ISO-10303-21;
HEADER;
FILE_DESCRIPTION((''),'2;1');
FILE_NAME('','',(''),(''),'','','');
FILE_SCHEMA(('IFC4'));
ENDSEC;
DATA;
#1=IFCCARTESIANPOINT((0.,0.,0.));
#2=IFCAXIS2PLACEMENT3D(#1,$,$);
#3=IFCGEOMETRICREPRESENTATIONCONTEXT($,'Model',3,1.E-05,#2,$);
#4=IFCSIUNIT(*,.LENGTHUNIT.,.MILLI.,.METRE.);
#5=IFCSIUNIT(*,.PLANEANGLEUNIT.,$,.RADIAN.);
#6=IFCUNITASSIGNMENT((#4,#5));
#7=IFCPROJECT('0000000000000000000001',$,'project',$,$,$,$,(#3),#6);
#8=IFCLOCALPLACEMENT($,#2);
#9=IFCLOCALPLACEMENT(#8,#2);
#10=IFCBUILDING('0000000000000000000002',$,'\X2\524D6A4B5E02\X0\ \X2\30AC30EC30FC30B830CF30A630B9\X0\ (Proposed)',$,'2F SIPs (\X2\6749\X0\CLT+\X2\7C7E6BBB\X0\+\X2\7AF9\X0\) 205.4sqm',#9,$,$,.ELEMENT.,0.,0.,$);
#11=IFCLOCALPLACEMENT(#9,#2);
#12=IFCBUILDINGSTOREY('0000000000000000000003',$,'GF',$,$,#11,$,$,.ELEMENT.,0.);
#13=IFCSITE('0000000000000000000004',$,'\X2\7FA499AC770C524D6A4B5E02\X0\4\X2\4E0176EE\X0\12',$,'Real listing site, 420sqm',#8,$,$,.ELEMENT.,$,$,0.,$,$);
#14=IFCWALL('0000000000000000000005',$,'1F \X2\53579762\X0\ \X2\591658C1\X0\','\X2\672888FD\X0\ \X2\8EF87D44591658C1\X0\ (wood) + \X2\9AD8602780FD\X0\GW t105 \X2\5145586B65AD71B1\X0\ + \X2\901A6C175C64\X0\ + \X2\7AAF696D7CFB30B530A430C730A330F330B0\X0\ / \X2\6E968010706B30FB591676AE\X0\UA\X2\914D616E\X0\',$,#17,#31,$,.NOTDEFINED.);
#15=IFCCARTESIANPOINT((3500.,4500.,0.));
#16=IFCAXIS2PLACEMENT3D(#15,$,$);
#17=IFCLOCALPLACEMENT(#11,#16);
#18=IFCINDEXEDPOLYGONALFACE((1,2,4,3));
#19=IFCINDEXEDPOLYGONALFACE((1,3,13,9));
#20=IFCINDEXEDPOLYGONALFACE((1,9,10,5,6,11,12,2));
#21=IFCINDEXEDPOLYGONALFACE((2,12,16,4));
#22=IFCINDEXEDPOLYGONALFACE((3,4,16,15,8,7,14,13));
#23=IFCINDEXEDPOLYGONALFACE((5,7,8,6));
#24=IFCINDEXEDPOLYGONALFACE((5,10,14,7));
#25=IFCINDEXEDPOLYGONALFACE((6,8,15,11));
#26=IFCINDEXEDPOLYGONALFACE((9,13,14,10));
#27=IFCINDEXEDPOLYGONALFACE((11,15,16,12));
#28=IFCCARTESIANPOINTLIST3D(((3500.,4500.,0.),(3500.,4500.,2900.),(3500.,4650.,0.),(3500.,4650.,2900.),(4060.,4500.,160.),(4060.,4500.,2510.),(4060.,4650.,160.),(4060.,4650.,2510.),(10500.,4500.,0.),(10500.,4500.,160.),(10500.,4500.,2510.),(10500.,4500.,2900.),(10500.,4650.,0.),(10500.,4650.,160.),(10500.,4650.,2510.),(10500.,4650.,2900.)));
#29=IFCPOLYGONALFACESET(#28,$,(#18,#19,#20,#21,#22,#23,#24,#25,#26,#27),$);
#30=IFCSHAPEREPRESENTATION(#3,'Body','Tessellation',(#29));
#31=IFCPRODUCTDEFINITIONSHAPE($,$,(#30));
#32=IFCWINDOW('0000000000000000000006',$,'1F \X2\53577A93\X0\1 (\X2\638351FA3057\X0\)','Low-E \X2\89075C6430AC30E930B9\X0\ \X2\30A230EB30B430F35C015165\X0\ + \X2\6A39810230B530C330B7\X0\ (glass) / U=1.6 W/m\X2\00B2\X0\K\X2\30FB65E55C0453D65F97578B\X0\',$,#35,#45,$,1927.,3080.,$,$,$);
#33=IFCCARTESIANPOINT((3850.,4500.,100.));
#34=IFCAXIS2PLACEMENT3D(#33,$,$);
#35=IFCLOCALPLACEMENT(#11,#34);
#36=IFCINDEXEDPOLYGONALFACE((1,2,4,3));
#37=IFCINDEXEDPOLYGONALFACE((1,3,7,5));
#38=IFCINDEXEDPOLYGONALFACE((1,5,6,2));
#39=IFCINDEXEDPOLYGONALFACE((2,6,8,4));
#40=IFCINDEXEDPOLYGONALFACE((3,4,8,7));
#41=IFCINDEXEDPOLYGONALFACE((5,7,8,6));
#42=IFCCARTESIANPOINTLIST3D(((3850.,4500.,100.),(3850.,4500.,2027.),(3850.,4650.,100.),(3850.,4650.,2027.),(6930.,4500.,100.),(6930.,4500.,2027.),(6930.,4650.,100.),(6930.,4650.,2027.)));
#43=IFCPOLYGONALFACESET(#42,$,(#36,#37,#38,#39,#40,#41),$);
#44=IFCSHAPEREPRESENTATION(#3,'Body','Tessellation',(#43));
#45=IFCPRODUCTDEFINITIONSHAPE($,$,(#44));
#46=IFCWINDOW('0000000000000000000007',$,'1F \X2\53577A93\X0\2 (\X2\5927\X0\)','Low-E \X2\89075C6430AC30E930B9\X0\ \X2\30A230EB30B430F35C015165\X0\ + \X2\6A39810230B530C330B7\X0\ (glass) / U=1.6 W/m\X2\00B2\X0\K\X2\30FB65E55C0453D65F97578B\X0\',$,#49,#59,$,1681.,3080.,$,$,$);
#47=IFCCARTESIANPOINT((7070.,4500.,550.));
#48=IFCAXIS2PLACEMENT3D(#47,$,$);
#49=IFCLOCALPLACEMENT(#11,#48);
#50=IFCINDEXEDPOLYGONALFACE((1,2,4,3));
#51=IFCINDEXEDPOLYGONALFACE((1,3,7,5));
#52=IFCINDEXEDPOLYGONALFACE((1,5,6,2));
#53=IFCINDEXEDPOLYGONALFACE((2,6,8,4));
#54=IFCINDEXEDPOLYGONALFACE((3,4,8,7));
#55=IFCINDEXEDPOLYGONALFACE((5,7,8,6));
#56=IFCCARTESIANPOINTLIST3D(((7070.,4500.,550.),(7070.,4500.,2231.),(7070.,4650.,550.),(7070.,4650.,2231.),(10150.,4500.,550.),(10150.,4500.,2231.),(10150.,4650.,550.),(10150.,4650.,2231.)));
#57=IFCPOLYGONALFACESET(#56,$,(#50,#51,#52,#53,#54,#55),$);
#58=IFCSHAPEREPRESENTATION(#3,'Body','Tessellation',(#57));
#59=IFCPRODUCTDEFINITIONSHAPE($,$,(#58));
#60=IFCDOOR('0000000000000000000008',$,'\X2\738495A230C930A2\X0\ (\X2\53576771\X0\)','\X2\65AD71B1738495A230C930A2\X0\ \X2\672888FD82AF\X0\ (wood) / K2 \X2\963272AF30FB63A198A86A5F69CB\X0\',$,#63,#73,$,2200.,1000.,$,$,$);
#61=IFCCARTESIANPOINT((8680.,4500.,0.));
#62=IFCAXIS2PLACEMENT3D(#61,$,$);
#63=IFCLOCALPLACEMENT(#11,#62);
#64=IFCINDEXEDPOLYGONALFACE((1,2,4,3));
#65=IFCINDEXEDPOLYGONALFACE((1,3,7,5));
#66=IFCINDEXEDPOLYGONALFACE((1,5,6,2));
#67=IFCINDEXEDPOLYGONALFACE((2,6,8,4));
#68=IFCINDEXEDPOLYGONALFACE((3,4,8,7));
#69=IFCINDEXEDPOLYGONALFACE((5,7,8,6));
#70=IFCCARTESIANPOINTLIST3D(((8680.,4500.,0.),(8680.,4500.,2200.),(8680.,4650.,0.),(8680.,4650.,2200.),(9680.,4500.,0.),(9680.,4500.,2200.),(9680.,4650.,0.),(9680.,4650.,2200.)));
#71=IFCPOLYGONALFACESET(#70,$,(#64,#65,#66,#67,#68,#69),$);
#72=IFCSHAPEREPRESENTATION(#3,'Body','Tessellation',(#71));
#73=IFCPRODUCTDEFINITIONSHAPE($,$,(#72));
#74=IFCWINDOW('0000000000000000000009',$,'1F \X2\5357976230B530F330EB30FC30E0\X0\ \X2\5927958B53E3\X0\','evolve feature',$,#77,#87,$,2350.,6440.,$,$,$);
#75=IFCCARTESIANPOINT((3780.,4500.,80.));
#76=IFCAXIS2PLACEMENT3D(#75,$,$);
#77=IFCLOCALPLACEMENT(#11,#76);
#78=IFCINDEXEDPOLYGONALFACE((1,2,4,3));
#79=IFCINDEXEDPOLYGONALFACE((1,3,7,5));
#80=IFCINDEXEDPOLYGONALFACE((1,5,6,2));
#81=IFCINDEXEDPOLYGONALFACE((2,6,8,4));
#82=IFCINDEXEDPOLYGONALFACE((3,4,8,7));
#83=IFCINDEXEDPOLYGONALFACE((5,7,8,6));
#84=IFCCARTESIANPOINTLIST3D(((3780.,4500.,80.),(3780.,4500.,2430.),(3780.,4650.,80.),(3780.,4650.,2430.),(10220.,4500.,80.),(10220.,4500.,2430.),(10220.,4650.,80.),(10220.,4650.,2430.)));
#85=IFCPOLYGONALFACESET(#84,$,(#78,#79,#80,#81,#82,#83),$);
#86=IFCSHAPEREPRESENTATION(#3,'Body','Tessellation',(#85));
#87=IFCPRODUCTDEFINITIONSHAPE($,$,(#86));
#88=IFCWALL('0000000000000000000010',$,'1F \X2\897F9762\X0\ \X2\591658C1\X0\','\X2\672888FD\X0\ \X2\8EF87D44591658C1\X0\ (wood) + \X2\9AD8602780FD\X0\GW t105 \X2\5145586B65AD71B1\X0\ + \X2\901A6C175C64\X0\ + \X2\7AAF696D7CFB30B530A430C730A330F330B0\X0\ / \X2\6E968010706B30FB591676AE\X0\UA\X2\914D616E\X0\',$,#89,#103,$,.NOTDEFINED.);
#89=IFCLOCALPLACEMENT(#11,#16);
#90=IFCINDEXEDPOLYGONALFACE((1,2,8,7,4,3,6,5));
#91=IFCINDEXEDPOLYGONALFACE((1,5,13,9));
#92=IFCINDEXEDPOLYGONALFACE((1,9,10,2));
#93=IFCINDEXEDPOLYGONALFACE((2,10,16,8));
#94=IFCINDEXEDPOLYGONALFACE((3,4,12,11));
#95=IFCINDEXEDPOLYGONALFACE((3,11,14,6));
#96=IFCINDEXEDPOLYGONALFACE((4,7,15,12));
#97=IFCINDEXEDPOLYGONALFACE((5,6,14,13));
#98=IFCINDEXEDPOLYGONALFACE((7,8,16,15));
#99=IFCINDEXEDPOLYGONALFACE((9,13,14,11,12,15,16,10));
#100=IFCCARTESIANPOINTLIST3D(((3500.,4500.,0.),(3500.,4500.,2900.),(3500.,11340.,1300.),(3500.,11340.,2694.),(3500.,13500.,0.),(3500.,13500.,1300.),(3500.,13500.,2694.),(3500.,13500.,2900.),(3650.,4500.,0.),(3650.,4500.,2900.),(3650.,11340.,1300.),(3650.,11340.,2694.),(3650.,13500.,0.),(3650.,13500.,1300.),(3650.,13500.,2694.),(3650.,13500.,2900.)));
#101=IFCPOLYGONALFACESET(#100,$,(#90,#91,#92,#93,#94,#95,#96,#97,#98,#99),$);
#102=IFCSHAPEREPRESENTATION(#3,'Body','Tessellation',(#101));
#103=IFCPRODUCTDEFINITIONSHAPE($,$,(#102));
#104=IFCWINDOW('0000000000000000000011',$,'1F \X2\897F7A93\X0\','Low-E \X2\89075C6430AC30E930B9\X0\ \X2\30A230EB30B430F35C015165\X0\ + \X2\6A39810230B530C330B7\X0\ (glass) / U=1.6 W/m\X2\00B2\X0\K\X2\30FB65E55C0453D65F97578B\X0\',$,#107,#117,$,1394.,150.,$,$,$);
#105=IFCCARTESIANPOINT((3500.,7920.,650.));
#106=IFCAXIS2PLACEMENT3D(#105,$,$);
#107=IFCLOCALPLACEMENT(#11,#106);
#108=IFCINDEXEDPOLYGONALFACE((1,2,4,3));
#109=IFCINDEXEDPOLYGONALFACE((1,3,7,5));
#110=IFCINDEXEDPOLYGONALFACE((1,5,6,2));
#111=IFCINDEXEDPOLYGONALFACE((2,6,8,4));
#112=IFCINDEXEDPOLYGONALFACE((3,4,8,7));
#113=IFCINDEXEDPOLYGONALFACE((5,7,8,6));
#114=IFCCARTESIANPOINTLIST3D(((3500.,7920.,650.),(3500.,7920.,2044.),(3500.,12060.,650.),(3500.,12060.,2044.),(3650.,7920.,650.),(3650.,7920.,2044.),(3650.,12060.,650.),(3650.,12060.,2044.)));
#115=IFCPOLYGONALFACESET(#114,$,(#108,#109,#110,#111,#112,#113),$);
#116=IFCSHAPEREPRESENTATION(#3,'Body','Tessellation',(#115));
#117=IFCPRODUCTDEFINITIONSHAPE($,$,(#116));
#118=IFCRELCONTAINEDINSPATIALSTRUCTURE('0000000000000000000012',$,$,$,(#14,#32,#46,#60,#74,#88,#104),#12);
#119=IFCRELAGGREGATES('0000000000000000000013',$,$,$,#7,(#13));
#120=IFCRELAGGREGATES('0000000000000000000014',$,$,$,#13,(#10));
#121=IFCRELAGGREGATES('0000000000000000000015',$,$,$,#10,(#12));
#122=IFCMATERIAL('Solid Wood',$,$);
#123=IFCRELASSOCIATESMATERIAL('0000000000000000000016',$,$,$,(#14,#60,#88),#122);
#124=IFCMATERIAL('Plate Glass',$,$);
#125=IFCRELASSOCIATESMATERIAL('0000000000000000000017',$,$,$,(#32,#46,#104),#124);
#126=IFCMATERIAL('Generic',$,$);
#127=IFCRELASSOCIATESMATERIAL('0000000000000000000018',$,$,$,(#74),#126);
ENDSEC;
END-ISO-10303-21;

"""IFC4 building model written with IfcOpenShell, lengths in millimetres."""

from ifc_helpers import new_model, si_unit, frame, frame_2d, origin, place, context, project, spatial, rectangle, extrude, material, element, fill, save


model = new_model("IFC4")

# Units and contexts
model_context = context("Model", 3, precision=1e-05, world=origin())
ifc_project = project(units=[si_unit("LENGTHUNIT", "METRE", prefix="MILLI"), si_unit("PLANEANGLEUNIT", "RADIAN")], contexts=[model_context])

# Site, building, storey
site_placement = place(None, origin())
site = spatial("IfcSite", under=ifc_project, at=site_placement, Name="群馬県前橋市4丁目12", ObjectType="Real listing site, 420sqm", CompositionType="ELEMENT", RefElevation=0.0)
building_placement = place(site_placement, origin())
building = spatial("IfcBuilding", under=site, at=building_placement, Name="前橋市 ガレージハウス (Proposed)", ObjectType="2F SIPs (杉CLT+籾殻+竹) 205.4sqm", CompositionType="ELEMENT", ElevationOfRefHeight=0.0, ElevationOfTerrain=0.0)
storey_placement = place(building_placement, origin())
storey = spatial("IfcBuildingStorey", under=building, at=storey_placement, Name="GF", CompositionType="ELEMENT", Elevation=0.0)

# Shared definitions
ifc_material_1 = material(Name="Solid Wood")

# Wall, openings, windows, door
wall_1_placement = place(storey_placement, frame((3500.0, 4500.0, 0.0)))
wall_1 = element("IfcWall", 1, at=wall_1_placement, inside=storey, material=ifc_material_1, Name="1F 南面 外壁", Description="木製 軸組外壁 (wood) + 高性能GW t105 充填断熱 + 通気層 + 窯業系サイディング / 準耐火・外皮UA配慮", PredefinedType="NOTDEFINED", context=model_context, shape_type="SweptSolid", body=[
    extrude(rectangle(XDim=7000.0, YDim=150.0, at=frame_2d((3500.0, 75.0))), frame((3500.0, 4500.0, 0.0)), (0.0, 0.0, 1.0), 2900.0),
])
opening_1_placement = place(storey_placement, frame((3850.0, 4500.0, 100.0)))
opening_1 = element("IfcOpeningElement", 2, at=opening_1_placement, cuts=wall_1, PredefinedType="NOTDEFINED", context=model_context, shape_type="SweptSolid", body=[
    extrude(rectangle(XDim=3080.0, YDim=150.0, at=frame_2d((1540.0, 75.0))), frame((3850.0, 4500.0, 100.0)), (0.0, 0.0, 1.0), 1927.0),
])
opening_2_placement = place(storey_placement, frame((7070.0, 4500.0, 550.0)))
opening_2 = element("IfcOpeningElement", 3, at=opening_2_placement, cuts=wall_1, PredefinedType="NOTDEFINED", context=model_context, shape_type="SweptSolid", body=[
    extrude(rectangle(XDim=3080.0, YDim=150.0, at=frame_2d((1540.0, 75.0))), frame((7070.0, 4500.0, 550.0)), (0.0, 0.0, 1.0), 1681.0),
])
opening_3_placement = place(storey_placement, frame((8680.0, 4500.0, 0.0)))
opening_3 = element("IfcOpeningElement", 4, at=opening_3_placement, cuts=wall_1, PredefinedType="NOTDEFINED", context=model_context, shape_type="SweptSolid", body=[
    extrude(rectangle(XDim=1000.0, YDim=150.0, at=frame_2d((500.0, 75.0))), frame((8680.0, 4500.0, 0.0)), (0.0, 0.0, 1.0), 2200.0),
])
opening_4_placement = place(storey_placement, frame((3780.0, 4500.0, 80.0)))
opening_4 = element("IfcOpeningElement", 5, at=opening_4_placement, cuts=wall_1, PredefinedType="NOTDEFINED", context=model_context, shape_type="SweptSolid", body=[
    extrude(rectangle(XDim=6440.0, YDim=150.0, at=frame_2d((3220.0, 75.0))), frame((3780.0, 4500.0, 80.0)), (0.0, 0.0, 1.0), 2350.0),
])
ifc_material_2 = material(Name="Plate Glass")
window_1_placement = place(storey_placement, frame((3850.0, 4500.0, 100.0)))
window_1 = element("IfcWindow", 6, at=window_1_placement, inside=storey, material=ifc_material_2, Name="1F 南窓1 (掃出し)", Description="Low-E 複層ガラス アルゴン封入 + 樹脂サッシ (glass) / U=1.6 W/m²K・日射取得型", OverallHeight=1927.0, OverallWidth=3080.0, context=model_context, shape_type="SweptSolid", body=[
    extrude(rectangle(XDim=3080.0, YDim=150.0, at=frame_2d((1540.0, 75.0))), frame((3850.0, 4500.0, 100.0)), (0.0, 0.0, 1.0), 1927.0),
])
fill(opening_1, window_1)
window_2_placement = place(storey_placement, frame((7070.0, 4500.0, 550.0)))
window_2 = element("IfcWindow", 7, at=window_2_placement, inside=storey, material=ifc_material_2, Name="1F 南窓2 (大)", Description="Low-E 複層ガラス アルゴン封入 + 樹脂サッシ (glass) / U=1.6 W/m²K・日射取得型", OverallHeight=1681.0, OverallWidth=3080.0, context=model_context, shape_type="SweptSolid", body=[
    extrude(rectangle(XDim=3080.0, YDim=150.0, at=frame_2d((1540.0, 75.0))), frame((7070.0, 4500.0, 550.0)), (0.0, 0.0, 1.0), 1681.0),
])
fill(opening_2, window_2)
door_placement = place(storey_placement, frame((8680.0, 4500.0, 0.0)))
door = element("IfcDoor", 8, at=door_placement, inside=storey, material=ifc_material_1, Name="玄関ドア (南東)", Description="断熱玄関ドア 木製芯 (wood) / K2 防犯・採風機構", OverallHeight=2200.0, OverallWidth=1000.0, context=model_context, shape_type="SweptSolid", body=[
    extrude(rectangle(XDim=1000.0, YDim=150.0, at=frame_2d((500.0, 75.0))), frame((8680.0, 4500.0, 0.0)), (0.0, 0.0, 1.0), 2200.0),
])
fill(opening_3, door)
ifc_material_3 = material(Name="Generic")
window_3_placement = place(storey_placement, frame((3780.0, 4500.0, 80.0)))
window_3 = element("IfcWindow", 9, at=window_3_placement, inside=storey, material=ifc_material_3, Name="1F 南面サンルーム 大開口", Description="evolve feature", OverallHeight=2350.0, OverallWidth=6440.0, context=model_context, shape_type="SweptSolid", body=[
    extrude(rectangle(XDim=6440.0, YDim=150.0, at=frame_2d((3220.0, 75.0))), frame((3780.0, 4500.0, 80.0)), (0.0, 0.0, 1.0), 2350.0),
])
fill(opening_4, window_3)

# Wall, opening, window
wall_2_placement = place(storey_placement, frame((3500.0, 4500.0, 0.0)))
wall_2 = element("IfcWall", 10, at=wall_2_placement, inside=storey, material=ifc_material_1, Name="1F 西面 外壁", Description="木製 軸組外壁 (wood) + 高性能GW t105 充填断熱 + 通気層 + 窯業系サイディング / 準耐火・外皮UA配慮", PredefinedType="NOTDEFINED", context=model_context, shape_type="SweptSolid", body=[
    extrude(rectangle(XDim=150.0, YDim=9000.0, at=frame_2d((75.0, 4500.0))), frame((3500.0, 4500.0, 0.0)), (0.0, 0.0, 1.0), 2900.0),
])
opening_5_placement = place(storey_placement, frame((3500.0, 7920.0, 650.0)))
opening_5 = element("IfcOpeningElement", 11, at=opening_5_placement, cuts=wall_2, PredefinedType="NOTDEFINED", context=model_context, shape_type="SweptSolid", body=[
    extrude(rectangle(XDim=150.0, YDim=4140.0, at=frame_2d((75.0, 2070.0))), frame((3500.0, 7920.0, 650.0)), (0.0, 0.0, 1.0), 1394.0),
])
window_4_placement = place(storey_placement, frame((3500.0, 7920.0, 650.0)))
window_4 = element("IfcWindow", 12, at=window_4_placement, inside=storey, material=ifc_material_2, Name="1F 西窓", Description="Low-E 複層ガラス アルゴン封入 + 樹脂サッシ (glass) / U=1.6 W/m²K・日射取得型", OverallHeight=1394.0, OverallWidth=150.0, context=model_context, shape_type="SweptSolid", body=[
    extrude(rectangle(XDim=150.0, YDim=4140.0, at=frame_2d((75.0, 2070.0))), frame((3500.0, 7920.0, 650.0)), (0.0, 0.0, 1.0), 1394.0),
])
fill(opening_5, window_4)

save(model, "model.ifc")
